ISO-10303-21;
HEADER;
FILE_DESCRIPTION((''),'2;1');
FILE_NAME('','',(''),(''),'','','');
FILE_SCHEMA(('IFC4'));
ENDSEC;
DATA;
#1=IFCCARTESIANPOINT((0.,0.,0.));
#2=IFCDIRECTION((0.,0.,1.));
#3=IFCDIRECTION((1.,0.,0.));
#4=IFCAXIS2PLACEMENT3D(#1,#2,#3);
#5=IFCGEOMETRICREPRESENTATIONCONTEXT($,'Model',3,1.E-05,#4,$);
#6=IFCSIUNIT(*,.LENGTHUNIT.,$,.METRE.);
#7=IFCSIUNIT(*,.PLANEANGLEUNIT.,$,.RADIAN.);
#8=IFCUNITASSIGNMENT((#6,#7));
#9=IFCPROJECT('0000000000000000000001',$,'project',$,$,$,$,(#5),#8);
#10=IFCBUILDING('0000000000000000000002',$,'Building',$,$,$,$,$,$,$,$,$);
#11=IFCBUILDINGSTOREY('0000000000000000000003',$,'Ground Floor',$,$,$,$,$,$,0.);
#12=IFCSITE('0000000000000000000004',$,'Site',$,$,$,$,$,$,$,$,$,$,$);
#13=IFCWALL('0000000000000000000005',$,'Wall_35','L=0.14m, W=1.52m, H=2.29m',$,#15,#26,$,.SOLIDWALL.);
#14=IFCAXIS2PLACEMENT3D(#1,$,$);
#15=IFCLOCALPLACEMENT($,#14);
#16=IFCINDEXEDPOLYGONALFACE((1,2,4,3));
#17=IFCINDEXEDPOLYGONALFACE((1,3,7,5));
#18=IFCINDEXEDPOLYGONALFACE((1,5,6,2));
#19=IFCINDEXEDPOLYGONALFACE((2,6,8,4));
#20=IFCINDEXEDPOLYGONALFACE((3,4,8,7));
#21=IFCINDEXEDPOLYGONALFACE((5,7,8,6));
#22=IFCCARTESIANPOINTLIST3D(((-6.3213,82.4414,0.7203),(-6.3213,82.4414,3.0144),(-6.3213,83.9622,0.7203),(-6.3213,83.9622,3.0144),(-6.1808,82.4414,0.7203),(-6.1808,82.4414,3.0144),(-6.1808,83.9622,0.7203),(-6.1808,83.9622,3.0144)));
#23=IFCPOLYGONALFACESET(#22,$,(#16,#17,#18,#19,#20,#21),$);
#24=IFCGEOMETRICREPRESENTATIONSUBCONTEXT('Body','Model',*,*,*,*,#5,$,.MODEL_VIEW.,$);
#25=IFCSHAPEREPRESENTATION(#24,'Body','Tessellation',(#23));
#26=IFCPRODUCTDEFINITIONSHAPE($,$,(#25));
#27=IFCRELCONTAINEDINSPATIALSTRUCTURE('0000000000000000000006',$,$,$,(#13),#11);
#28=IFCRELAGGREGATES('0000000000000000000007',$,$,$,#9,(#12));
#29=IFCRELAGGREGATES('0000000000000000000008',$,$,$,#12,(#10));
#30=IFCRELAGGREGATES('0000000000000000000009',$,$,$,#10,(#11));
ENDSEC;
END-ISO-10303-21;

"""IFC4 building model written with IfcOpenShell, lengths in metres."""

from ifc_helpers import new_model, si_unit, frame, origin_with_axes, origin_2d, context, subcontext, project, spatial, rectangle, extrude, element, save


model = new_model("IFC4")

# Units and contexts
model_context = context("Model", 3, precision=1e-05, world=origin_with_axes())
body_context = subcontext(model_context, "Body", "Model", "MODEL_VIEW")
ifc_project = project(units=[si_unit("LENGTHUNIT", "METRE"), si_unit("PLANEANGLEUNIT", "RADIAN")], contexts=[model_context])

# Site, building, storey
site = spatial("IfcSite", under=ifc_project, Name="Site")
building = spatial("IfcBuilding", under=site, Name="Building")
storey = spatial("IfcBuildingStorey", under=building, Name="Ground Floor", Elevation=0.0)

# Wall
element("IfcWall", 1, inside=storey, Name="Wall_35", Description="L=0.14m, W=1.52m, H=2.29m", PredefinedType="SOLIDWALL", context=body_context, shape_type="SweptSolid", body=[
    extrude(rectangle(XDim=0.1405, YDim=1.5208, at=origin_2d()), frame((-6.2511, 83.2018, 0.7203), z_axis=(0.0, 0.0, 1.0), x_axis=(1.0, 0.0, 0.0)), (0.0, 0.0, 1.0), 2.2941),
])

save(model, "model.ifc")
